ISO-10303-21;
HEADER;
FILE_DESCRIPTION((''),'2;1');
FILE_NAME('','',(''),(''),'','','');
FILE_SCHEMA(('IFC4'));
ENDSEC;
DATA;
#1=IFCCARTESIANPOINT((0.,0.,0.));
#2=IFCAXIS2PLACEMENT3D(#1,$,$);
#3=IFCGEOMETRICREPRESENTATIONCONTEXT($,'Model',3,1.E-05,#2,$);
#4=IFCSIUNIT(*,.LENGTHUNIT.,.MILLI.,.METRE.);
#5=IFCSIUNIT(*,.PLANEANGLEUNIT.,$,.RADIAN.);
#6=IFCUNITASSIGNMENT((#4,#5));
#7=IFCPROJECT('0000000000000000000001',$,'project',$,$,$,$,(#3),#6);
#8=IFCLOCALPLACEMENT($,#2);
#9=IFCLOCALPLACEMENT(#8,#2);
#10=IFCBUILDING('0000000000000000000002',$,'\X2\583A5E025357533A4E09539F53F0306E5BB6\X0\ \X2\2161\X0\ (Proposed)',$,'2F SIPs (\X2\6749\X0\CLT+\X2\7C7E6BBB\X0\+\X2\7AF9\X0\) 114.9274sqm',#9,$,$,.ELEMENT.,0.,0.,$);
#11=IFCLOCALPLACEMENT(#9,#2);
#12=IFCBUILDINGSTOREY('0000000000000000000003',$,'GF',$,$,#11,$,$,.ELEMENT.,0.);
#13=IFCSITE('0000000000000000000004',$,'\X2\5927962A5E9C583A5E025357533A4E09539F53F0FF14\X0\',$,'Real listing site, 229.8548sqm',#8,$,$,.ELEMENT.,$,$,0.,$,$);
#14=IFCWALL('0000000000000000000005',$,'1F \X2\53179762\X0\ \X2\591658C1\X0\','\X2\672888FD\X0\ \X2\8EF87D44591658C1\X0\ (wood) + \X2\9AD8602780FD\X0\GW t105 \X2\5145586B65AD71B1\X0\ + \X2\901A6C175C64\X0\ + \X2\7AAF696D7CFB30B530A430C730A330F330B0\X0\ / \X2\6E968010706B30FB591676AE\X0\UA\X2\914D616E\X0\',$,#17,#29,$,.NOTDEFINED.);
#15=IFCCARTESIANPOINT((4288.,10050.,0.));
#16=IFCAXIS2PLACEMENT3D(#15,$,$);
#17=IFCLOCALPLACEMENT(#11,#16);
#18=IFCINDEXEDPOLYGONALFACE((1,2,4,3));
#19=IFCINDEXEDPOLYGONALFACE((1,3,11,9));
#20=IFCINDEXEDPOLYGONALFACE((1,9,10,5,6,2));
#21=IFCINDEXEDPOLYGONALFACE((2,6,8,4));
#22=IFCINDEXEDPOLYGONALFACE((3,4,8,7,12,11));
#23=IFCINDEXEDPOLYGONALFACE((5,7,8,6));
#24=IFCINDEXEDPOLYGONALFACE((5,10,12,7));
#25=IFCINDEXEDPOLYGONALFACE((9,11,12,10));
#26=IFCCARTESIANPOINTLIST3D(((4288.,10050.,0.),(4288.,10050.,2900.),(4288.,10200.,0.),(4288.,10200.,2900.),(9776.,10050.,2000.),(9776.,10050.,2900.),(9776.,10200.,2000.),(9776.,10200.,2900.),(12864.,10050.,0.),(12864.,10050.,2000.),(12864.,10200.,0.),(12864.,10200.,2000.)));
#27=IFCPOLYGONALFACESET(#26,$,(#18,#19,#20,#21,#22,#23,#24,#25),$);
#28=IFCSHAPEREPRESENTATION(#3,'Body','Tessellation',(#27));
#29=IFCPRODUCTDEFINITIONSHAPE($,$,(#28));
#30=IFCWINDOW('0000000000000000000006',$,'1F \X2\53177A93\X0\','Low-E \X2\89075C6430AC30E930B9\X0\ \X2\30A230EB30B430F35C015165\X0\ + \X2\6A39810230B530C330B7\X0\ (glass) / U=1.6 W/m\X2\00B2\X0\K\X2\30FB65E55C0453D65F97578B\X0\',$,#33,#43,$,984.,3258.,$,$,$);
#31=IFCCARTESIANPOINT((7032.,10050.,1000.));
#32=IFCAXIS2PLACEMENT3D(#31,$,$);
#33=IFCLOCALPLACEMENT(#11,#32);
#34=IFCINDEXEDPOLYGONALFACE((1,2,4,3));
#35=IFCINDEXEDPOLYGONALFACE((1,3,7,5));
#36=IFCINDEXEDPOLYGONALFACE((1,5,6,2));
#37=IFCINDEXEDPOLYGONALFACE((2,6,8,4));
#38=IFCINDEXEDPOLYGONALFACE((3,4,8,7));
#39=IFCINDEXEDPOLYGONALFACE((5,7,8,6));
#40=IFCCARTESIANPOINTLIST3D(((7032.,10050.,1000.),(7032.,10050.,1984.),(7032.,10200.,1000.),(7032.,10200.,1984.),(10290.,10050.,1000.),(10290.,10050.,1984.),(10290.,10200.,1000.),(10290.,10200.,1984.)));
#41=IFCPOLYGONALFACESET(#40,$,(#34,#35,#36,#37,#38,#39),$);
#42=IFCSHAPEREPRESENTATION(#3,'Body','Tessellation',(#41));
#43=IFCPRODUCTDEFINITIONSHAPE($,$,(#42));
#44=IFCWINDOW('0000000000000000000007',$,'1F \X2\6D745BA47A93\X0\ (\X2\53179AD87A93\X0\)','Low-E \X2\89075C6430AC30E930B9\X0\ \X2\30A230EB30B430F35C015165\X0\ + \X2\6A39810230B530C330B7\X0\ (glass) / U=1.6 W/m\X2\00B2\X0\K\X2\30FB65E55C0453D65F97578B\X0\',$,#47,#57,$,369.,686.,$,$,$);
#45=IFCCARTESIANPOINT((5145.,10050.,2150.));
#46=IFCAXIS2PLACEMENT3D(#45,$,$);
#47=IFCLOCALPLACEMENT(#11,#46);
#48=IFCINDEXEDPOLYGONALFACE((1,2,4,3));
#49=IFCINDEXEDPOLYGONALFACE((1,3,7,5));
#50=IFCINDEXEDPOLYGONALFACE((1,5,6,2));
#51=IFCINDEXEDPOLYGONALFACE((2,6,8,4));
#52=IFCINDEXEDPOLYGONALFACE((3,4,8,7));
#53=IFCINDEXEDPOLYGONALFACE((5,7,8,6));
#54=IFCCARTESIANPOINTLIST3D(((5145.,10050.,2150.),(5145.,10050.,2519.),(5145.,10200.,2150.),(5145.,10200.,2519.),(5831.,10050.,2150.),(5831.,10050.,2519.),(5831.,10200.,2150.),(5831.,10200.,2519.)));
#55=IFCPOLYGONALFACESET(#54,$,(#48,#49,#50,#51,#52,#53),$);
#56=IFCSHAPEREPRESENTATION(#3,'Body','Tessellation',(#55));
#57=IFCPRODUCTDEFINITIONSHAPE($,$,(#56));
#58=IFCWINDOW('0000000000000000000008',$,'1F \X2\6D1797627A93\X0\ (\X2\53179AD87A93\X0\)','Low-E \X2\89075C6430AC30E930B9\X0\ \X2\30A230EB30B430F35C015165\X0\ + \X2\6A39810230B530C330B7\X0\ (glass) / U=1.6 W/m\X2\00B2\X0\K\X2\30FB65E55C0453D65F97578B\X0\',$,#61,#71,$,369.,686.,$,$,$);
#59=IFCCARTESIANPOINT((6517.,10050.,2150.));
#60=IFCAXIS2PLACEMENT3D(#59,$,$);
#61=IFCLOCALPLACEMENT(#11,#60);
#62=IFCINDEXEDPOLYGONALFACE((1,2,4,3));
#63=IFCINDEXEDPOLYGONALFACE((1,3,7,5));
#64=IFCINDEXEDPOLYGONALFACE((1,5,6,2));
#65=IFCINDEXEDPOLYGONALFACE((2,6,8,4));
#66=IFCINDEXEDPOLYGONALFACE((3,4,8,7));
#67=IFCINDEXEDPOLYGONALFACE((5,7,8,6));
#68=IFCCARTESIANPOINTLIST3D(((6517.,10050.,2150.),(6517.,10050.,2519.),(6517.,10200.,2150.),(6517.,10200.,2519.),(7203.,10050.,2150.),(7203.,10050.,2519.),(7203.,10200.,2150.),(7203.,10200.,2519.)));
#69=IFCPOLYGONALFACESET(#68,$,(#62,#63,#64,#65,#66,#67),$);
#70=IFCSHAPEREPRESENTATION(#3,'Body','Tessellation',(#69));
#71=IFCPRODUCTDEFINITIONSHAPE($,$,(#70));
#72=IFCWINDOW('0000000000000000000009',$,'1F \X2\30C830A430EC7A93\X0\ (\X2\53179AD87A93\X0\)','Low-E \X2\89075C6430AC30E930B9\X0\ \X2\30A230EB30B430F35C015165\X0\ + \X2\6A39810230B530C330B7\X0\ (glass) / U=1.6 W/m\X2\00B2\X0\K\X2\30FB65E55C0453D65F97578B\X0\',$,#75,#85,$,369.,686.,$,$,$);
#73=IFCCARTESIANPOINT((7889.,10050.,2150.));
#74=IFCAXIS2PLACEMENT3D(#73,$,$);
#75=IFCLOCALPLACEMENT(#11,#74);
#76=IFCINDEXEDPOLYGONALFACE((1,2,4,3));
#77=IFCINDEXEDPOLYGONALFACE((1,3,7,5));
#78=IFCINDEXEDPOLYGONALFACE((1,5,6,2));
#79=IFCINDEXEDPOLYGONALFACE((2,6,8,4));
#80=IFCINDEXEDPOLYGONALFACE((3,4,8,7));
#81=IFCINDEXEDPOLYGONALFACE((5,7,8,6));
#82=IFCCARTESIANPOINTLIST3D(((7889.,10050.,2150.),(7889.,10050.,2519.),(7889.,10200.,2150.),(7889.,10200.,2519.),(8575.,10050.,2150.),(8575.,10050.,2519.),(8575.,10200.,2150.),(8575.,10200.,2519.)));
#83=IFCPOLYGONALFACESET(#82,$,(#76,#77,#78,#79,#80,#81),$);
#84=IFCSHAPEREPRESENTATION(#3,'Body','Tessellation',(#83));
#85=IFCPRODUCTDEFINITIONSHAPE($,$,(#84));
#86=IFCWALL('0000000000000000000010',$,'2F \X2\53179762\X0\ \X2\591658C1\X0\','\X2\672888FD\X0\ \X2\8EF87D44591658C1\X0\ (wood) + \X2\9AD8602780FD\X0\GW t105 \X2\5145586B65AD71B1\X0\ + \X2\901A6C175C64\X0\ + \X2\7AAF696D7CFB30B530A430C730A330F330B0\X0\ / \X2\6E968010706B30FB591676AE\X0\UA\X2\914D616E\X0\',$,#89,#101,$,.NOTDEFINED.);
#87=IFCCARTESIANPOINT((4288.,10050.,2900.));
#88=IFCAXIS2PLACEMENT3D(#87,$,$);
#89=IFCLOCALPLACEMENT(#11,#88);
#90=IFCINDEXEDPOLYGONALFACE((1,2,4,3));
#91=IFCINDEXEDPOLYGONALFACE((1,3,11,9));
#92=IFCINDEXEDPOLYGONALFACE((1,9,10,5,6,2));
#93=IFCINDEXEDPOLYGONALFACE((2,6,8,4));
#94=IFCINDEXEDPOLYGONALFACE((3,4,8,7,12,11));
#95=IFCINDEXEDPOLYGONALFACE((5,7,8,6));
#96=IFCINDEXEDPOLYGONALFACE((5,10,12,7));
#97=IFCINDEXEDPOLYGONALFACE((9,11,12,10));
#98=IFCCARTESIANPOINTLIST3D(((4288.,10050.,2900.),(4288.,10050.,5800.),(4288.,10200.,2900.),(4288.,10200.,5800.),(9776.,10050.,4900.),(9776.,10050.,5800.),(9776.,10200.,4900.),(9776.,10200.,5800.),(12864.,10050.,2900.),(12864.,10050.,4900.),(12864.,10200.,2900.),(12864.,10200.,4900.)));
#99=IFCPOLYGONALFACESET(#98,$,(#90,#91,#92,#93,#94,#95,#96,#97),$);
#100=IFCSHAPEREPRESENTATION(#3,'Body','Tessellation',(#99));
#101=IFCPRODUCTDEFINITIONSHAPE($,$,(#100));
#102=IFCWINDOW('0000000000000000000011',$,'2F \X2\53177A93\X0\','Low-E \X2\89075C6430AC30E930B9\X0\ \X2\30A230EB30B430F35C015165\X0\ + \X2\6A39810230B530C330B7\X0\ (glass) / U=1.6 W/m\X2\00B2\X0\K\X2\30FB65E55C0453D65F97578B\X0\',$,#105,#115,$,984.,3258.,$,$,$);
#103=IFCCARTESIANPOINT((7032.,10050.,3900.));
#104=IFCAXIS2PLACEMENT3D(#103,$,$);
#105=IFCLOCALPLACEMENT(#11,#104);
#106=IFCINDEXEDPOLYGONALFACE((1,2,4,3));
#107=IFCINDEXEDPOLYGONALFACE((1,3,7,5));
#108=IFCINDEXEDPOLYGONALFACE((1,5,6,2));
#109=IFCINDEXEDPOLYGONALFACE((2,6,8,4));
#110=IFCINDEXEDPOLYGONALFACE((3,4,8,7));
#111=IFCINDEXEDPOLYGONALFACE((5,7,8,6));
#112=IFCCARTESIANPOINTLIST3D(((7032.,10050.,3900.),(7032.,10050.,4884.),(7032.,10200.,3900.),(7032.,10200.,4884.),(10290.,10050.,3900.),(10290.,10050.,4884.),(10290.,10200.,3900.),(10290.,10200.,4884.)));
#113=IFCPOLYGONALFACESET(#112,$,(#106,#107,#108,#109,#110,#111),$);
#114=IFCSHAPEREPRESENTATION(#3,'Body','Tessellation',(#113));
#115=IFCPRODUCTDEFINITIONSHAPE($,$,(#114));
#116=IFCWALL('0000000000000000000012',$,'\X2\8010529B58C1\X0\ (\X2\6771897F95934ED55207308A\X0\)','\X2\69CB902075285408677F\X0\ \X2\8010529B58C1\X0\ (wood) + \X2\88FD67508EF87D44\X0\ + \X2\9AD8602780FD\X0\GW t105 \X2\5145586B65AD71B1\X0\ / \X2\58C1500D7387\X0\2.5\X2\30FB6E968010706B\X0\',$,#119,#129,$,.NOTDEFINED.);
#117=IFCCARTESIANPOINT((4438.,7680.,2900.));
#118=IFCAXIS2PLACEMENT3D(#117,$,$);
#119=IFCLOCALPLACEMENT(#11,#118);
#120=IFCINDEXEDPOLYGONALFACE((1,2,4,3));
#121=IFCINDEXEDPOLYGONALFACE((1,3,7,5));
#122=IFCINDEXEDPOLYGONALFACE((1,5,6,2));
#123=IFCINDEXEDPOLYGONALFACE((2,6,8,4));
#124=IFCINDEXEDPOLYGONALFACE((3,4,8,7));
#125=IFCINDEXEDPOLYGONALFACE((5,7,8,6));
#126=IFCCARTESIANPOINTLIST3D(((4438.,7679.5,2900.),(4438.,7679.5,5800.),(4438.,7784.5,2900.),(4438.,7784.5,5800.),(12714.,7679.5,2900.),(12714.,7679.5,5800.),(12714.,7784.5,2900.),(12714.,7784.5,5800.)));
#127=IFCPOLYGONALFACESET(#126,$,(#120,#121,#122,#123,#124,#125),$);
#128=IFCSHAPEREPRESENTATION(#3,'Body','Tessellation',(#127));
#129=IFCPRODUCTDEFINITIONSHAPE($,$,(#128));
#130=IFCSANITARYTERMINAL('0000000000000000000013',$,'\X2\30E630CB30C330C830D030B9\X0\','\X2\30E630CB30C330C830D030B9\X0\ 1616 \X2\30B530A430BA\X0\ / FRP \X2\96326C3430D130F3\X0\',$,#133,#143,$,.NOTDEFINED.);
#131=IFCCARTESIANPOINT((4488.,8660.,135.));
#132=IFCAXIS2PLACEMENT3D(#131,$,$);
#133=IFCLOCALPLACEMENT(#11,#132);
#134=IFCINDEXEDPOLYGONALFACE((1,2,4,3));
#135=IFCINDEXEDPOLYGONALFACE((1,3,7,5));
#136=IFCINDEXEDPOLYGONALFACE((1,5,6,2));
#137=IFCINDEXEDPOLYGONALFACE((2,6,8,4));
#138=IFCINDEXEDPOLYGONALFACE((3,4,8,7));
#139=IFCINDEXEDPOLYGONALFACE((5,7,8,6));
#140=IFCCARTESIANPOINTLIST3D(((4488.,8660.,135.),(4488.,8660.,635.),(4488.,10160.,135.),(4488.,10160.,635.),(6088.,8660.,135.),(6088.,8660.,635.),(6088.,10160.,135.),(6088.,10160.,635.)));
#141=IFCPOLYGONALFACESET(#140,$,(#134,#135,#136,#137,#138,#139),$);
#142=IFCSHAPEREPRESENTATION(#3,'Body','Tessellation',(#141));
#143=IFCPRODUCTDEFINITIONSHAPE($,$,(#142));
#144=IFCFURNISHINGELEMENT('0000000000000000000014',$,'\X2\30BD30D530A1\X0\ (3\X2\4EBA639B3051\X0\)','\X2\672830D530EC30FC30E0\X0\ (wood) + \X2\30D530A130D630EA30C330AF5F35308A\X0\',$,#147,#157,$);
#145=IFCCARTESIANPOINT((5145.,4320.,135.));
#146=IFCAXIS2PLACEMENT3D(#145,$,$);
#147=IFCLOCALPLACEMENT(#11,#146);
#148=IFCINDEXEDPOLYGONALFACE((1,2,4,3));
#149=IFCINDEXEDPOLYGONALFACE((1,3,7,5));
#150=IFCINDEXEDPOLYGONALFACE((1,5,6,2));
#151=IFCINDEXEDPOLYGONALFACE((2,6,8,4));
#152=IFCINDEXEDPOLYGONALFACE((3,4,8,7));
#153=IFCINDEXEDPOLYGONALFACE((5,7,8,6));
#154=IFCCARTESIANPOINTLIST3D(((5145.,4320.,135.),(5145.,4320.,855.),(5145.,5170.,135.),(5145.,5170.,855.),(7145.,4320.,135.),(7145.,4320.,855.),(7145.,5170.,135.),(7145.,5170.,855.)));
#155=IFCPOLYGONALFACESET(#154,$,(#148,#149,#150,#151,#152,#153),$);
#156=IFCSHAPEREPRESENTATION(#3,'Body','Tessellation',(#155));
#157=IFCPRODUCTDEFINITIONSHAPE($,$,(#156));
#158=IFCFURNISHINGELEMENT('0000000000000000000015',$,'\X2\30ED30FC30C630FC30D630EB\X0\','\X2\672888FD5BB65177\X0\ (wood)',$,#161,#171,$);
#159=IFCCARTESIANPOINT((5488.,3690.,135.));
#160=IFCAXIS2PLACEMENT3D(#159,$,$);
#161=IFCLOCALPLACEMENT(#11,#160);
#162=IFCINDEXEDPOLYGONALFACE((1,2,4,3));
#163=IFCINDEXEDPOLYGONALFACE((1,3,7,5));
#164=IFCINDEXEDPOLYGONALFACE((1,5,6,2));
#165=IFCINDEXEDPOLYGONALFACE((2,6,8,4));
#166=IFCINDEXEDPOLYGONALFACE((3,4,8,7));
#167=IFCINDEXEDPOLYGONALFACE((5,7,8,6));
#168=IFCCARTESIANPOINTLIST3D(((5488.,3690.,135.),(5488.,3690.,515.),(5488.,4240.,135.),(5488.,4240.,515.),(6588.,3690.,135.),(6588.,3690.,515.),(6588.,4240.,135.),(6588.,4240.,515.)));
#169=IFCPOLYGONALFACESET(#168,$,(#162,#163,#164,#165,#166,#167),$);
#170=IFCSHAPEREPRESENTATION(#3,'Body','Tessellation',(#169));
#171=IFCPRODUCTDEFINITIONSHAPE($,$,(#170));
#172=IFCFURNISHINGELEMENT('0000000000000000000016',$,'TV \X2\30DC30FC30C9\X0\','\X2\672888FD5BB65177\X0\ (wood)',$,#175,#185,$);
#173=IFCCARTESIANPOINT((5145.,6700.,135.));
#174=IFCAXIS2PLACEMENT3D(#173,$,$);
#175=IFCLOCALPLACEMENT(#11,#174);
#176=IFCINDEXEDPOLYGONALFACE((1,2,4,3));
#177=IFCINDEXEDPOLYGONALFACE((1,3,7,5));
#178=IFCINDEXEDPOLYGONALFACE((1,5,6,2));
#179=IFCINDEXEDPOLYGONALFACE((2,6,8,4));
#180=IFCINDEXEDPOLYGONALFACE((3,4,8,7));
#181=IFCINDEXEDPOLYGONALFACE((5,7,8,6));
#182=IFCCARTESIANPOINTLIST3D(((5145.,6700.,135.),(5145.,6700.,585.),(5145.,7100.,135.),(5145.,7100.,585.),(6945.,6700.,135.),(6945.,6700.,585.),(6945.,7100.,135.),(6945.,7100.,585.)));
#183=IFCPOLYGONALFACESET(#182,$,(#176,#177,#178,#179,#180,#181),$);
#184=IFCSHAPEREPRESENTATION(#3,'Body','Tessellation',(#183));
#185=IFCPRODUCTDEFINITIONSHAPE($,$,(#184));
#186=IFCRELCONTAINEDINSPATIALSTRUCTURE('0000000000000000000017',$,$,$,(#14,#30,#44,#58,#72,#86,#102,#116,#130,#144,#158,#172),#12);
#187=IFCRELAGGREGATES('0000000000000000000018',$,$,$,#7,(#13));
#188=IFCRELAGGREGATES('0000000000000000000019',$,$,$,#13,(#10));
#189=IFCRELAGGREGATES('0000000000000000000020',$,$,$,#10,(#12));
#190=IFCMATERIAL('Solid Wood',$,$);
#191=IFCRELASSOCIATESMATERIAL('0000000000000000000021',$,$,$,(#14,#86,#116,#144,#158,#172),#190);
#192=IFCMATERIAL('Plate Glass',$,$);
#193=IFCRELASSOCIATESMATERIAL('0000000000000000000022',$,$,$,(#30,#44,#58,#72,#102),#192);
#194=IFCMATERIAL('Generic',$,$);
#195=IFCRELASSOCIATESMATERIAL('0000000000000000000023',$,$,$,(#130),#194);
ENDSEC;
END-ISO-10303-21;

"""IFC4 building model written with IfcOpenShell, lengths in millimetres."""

from ifc_helpers import new_model, si_unit, frame, frame_2d, origin, place, context, project, spatial, rectangle, extrude, material, element, fill, save


model = new_model("IFC4")

# Units and contexts
model_context = context("Model", 3, precision=1e-05, world=origin())
ifc_project = project(units=[si_unit("LENGTHUNIT", "METRE", prefix="MILLI"), si_unit("PLANEANGLEUNIT", "RADIAN")], contexts=[model_context])

# Site, building, storey
site_placement = place(None, origin())
site = spatial("IfcSite", under=ifc_project, at=site_placement, Name="大阪府堺市南区三原台４", ObjectType="Real listing site, 229.8548sqm", CompositionType="ELEMENT", RefElevation=0.0)
building_placement = place(site_placement, origin())
building = spatial("IfcBuilding", under=site, at=building_placement, Name="堺市南区三原台の家 Ⅱ (Proposed)", ObjectType="2F SIPs (杉CLT+籾殻+竹) 114.9274sqm", CompositionType="ELEMENT", ElevationOfRefHeight=0.0, ElevationOfTerrain=0.0)
storey_placement = place(building_placement, origin())
storey = spatial("IfcBuildingStorey", under=building, at=storey_placement, Name="GF", CompositionType="ELEMENT", Elevation=0.0)

# Wall, openings, windows
ifc_material_1 = material(Name="Solid Wood")
wall_1_placement = place(storey_placement, frame((4288.0, 10050.0, 0.0)))
wall_1 = element("IfcWall", 1, at=wall_1_placement, inside=storey, material=ifc_material_1, Name="1F 北面 外壁", Description="木製 軸組外壁 (wood) + 高性能GW t105 充填断熱 + 通気層 + 窯業系サイディング / 準耐火・外皮UA配慮", PredefinedType="NOTDEFINED", context=model_context, shape_type="SweptSolid", body=[
    extrude(rectangle(XDim=8576.0, YDim=150.0, at=frame_2d((4288.0, 75.0))), frame((4288.0, 10050.0, 0.0)), (0.0, 0.0, 1.0), 2900.0),
])
opening_1_placement = place(storey_placement, frame((7032.0, 10050.0, 1000.0)))
opening_1 = element("IfcOpeningElement", 2, at=opening_1_placement, cuts=wall_1, PredefinedType="NOTDEFINED", context=model_context, shape_type="SweptSolid", body=[
    extrude(rectangle(XDim=3258.0, YDim=150.0, at=frame_2d((1629.0, 75.0))), frame((7032.0, 10050.0, 1000.0)), (0.0, 0.0, 1.0), 984.0),
])
opening_2_placement = place(storey_placement, frame((5145.0, 10050.0, 2150.0)))
opening_2 = element("IfcOpeningElement", 3, at=opening_2_placement, cuts=wall_1, PredefinedType="NOTDEFINED", context=model_context, shape_type="SweptSolid", body=[
    extrude(rectangle(XDim=686.0, YDim=150.0, at=frame_2d((343.0, 75.0))), frame((5145.0, 10050.0, 2150.0)), (0.0, 0.0, 1.0), 369.0),
])
opening_3_placement = place(storey_placement, frame((6517.0, 10050.0, 2150.0)))
opening_3 = element("IfcOpeningElement", 4, at=opening_3_placement, cuts=wall_1, PredefinedType="NOTDEFINED", context=model_context, shape_type="SweptSolid", body=[
    extrude(rectangle(XDim=686.0, YDim=150.0, at=frame_2d((343.0, 75.0))), frame((6517.0, 10050.0, 2150.0)), (0.0, 0.0, 1.0), 369.0),
])
opening_4_placement = place(storey_placement, frame((7889.0, 10050.0, 2150.0)))
opening_4 = element("IfcOpeningElement", 5, at=opening_4_placement, cuts=wall_1, PredefinedType="NOTDEFINED", context=model_context, shape_type="SweptSolid", body=[
    extrude(rectangle(XDim=686.0, YDim=150.0, at=frame_2d((343.0, 75.0))), frame((7889.0, 10050.0, 2150.0)), (0.0, 0.0, 1.0), 369.0),
])
ifc_material_2 = material(Name="Plate Glass")
window_1_placement = place(storey_placement, frame((7032.0, 10050.0, 1000.0)))
window_1 = element("IfcWindow", 6, at=window_1_placement, inside=storey, material=ifc_material_2, Name="1F 北窓", Description="Low-E 複層ガラス アルゴン封入 + 樹脂サッシ (glass) / U=1.6 W/m²K・日射取得型", OverallHeight=984.0, OverallWidth=3258.0, context=model_context, shape_type="SweptSolid", body=[
    extrude(rectangle(XDim=3258.0, YDim=150.0, at=frame_2d((1629.0, 75.0))), frame((7032.0, 10050.0, 1000.0)), (0.0, 0.0, 1.0), 984.0),
])
fill(opening_1, window_1)
window_2_placement = place(storey_placement, frame((5145.0, 10050.0, 2150.0)))
window_2 = element("IfcWindow", 7, at=window_2_placement, inside=storey, material=ifc_material_2, Name="1F 浴室窓 (北高窓)", Description="Low-E 複層ガラス アルゴン封入 + 樹脂サッシ (glass) / U=1.6 W/m²K・日射取得型", OverallHeight=369.0, OverallWidth=686.0, context=model_context, shape_type="SweptSolid", body=[
    extrude(rectangle(XDim=686.0, YDim=150.0, at=frame_2d((343.0, 75.0))), frame((5145.0, 10050.0, 2150.0)), (0.0, 0.0, 1.0), 369.0),
])
fill(opening_2, window_2)
window_3_placement = place(storey_placement, frame((6517.0, 10050.0, 2150.0)))
window_3 = element("IfcWindow", 8, at=window_3_placement, inside=storey, material=ifc_material_2, Name="1F 洗面窓 (北高窓)", Description="Low-E 複層ガラス アルゴン封入 + 樹脂サッシ (glass) / U=1.6 W/m²K・日射取得型", OverallHeight=369.0, OverallWidth=686.0, context=model_context, shape_type="SweptSolid", body=[
    extrude(rectangle(XDim=686.0, YDim=150.0, at=frame_2d((343.0, 75.0))), frame((6517.0, 10050.0, 2150.0)), (0.0, 0.0, 1.0), 369.0),
])
fill(opening_3, window_3)
window_4_placement = place(storey_placement, frame((7889.0, 10050.0, 2150.0)))
window_4 = element("IfcWindow", 9, at=window_4_placement, inside=storey, material=ifc_material_2, Name="1F トイレ窓 (北高窓)", Description="Low-E 複層ガラス アルゴン封入 + 樹脂サッシ (glass) / U=1.6 W/m²K・日射取得型", OverallHeight=369.0, OverallWidth=686.0, context=model_context, shape_type="SweptSolid", body=[
    extrude(rectangle(XDim=686.0, YDim=150.0, at=frame_2d((343.0, 75.0))), frame((7889.0, 10050.0, 2150.0)), (0.0, 0.0, 1.0), 369.0),
])
fill(opening_4, window_4)

# Wall, opening, window
wall_2_placement = place(storey_placement, frame((4288.0, 10050.0, 2900.0)))
wall_2 = element("IfcWall", 10, at=wall_2_placement, inside=storey, material=ifc_material_1, Name="2F 北面 外壁", Description="木製 軸組外壁 (wood) + 高性能GW t105 充填断熱 + 通気層 + 窯業系サイディング / 準耐火・外皮UA配慮", PredefinedType="NOTDEFINED", context=model_context, shape_type="SweptSolid", body=[
    extrude(rectangle(XDim=8576.0, YDim=150.0, at=frame_2d((4288.0, 75.0))), frame((4288.0, 10050.0, 2900.0)), (0.0, 0.0, 1.0), 2900.0),
])
opening_5_placement = place(storey_placement, frame((7032.0, 10050.0, 3900.0)))
opening_5 = element("IfcOpeningElement", 11, at=opening_5_placement, cuts=wall_2, PredefinedType="NOTDEFINED", context=model_context, shape_type="SweptSolid", body=[
    extrude(rectangle(XDim=3258.0, YDim=150.0, at=frame_2d((1629.0, 75.0))), frame((7032.0, 10050.0, 3900.0)), (0.0, 0.0, 1.0), 984.0),
])
window_5_placement = place(storey_placement, frame((7032.0, 10050.0, 3900.0)))
window_5 = element("IfcWindow", 12, at=window_5_placement, inside=storey, material=ifc_material_2, Name="2F 北窓", Description="Low-E 複層ガラス アルゴン封入 + 樹脂サッシ (glass) / U=1.6 W/m²K・日射取得型", OverallHeight=984.0, OverallWidth=3258.0, context=model_context, shape_type="SweptSolid", body=[
    extrude(rectangle(XDim=3258.0, YDim=150.0, at=frame_2d((1629.0, 75.0))), frame((7032.0, 10050.0, 3900.0)), (0.0, 0.0, 1.0), 984.0),
])
fill(opening_5, window_5)

# Wall
wall_3_placement = place(storey_placement, frame((4438.0, 7680.0, 2900.0)))
element("IfcWall", 13, at=wall_3_placement, inside=storey, material=ifc_material_1, Name="耐力壁 (東西間仕切り)", Description="構造用合板 耐力壁 (wood) + 製材軸組 + 高性能GW t105 充填断熱 / 壁倍率2.5・準耐火", PredefinedType="NOTDEFINED", context=model_context, shape_type="SweptSolid", body=[
    extrude(rectangle(XDim=8276.0, YDim=105.0, at=frame_2d((4138.0, 52.0))), frame((4438.0, 7680.0, 2900.0)), (0.0, 0.0, 1.0), 2900.0),
])

# Sanitary terminal
ifc_material_3 = material(Name="Generic")
sanitary_terminal_placement = place(storey_placement, frame((4488.0, 8660.0, 135.0)))
element("IfcSanitaryTerminal", 14, at=sanitary_terminal_placement, inside=storey, material=ifc_material_3, Name="ユニットバス", Description="ユニットバス 1616 サイズ / FRP 防水パン", PredefinedType="NOTDEFINED", context=model_context, shape_type="SweptSolid", body=[
    extrude(rectangle(XDim=1600.0, YDim=1500.0, at=frame_2d((800.0, 750.0))), frame((4488.0, 8660.0, 135.0)), (0.0, 0.0, 1.0), 500.0),
])

# Furnishing elements
furnishing_1_placement = place(storey_placement, frame((5145.0, 4320.0, 135.0)))
element("IfcFurnishingElement", 15, at=furnishing_1_placement, inside=storey, material=ifc_material_1, Name="ソファ (3人掛け)", Description="木フレーム (wood) + ファブリック張り", context=model_context, shape_type="SweptSolid", body=[
    extrude(rectangle(XDim=2000.0, YDim=850.0, at=frame_2d((1000.0, 425.0))), frame((5145.0, 4320.0, 135.0)), (0.0, 0.0, 1.0), 720.0),
])
furnishing_2_placement = place(storey_placement, frame((5488.0, 3690.0, 135.0)))
element("IfcFurnishingElement", 16, at=furnishing_2_placement, inside=storey, material=ifc_material_1, Name="ローテーブル", Description="木製家具 (wood)", context=model_context, shape_type="SweptSolid", body=[
    extrude(rectangle(XDim=1100.0, YDim=550.0, at=frame_2d((550.0, 275.0))), frame((5488.0, 3690.0, 135.0)), (0.0, 0.0, 1.0), 380.0),
])
furnishing_3_placement = place(storey_placement, frame((5145.0, 6700.0, 135.0)))
element("IfcFurnishingElement", 17, at=furnishing_3_placement, inside=storey, material=ifc_material_1, Name="TV ボード", Description="木製家具 (wood)", context=model_context, shape_type="SweptSolid", body=[
    extrude(rectangle(XDim=1800.0, YDim=400.0, at=frame_2d((900.0, 200.0))), frame((5145.0, 6700.0, 135.0)), (0.0, 0.0, 1.0), 450.0),
])

save(model, "model.ifc")
